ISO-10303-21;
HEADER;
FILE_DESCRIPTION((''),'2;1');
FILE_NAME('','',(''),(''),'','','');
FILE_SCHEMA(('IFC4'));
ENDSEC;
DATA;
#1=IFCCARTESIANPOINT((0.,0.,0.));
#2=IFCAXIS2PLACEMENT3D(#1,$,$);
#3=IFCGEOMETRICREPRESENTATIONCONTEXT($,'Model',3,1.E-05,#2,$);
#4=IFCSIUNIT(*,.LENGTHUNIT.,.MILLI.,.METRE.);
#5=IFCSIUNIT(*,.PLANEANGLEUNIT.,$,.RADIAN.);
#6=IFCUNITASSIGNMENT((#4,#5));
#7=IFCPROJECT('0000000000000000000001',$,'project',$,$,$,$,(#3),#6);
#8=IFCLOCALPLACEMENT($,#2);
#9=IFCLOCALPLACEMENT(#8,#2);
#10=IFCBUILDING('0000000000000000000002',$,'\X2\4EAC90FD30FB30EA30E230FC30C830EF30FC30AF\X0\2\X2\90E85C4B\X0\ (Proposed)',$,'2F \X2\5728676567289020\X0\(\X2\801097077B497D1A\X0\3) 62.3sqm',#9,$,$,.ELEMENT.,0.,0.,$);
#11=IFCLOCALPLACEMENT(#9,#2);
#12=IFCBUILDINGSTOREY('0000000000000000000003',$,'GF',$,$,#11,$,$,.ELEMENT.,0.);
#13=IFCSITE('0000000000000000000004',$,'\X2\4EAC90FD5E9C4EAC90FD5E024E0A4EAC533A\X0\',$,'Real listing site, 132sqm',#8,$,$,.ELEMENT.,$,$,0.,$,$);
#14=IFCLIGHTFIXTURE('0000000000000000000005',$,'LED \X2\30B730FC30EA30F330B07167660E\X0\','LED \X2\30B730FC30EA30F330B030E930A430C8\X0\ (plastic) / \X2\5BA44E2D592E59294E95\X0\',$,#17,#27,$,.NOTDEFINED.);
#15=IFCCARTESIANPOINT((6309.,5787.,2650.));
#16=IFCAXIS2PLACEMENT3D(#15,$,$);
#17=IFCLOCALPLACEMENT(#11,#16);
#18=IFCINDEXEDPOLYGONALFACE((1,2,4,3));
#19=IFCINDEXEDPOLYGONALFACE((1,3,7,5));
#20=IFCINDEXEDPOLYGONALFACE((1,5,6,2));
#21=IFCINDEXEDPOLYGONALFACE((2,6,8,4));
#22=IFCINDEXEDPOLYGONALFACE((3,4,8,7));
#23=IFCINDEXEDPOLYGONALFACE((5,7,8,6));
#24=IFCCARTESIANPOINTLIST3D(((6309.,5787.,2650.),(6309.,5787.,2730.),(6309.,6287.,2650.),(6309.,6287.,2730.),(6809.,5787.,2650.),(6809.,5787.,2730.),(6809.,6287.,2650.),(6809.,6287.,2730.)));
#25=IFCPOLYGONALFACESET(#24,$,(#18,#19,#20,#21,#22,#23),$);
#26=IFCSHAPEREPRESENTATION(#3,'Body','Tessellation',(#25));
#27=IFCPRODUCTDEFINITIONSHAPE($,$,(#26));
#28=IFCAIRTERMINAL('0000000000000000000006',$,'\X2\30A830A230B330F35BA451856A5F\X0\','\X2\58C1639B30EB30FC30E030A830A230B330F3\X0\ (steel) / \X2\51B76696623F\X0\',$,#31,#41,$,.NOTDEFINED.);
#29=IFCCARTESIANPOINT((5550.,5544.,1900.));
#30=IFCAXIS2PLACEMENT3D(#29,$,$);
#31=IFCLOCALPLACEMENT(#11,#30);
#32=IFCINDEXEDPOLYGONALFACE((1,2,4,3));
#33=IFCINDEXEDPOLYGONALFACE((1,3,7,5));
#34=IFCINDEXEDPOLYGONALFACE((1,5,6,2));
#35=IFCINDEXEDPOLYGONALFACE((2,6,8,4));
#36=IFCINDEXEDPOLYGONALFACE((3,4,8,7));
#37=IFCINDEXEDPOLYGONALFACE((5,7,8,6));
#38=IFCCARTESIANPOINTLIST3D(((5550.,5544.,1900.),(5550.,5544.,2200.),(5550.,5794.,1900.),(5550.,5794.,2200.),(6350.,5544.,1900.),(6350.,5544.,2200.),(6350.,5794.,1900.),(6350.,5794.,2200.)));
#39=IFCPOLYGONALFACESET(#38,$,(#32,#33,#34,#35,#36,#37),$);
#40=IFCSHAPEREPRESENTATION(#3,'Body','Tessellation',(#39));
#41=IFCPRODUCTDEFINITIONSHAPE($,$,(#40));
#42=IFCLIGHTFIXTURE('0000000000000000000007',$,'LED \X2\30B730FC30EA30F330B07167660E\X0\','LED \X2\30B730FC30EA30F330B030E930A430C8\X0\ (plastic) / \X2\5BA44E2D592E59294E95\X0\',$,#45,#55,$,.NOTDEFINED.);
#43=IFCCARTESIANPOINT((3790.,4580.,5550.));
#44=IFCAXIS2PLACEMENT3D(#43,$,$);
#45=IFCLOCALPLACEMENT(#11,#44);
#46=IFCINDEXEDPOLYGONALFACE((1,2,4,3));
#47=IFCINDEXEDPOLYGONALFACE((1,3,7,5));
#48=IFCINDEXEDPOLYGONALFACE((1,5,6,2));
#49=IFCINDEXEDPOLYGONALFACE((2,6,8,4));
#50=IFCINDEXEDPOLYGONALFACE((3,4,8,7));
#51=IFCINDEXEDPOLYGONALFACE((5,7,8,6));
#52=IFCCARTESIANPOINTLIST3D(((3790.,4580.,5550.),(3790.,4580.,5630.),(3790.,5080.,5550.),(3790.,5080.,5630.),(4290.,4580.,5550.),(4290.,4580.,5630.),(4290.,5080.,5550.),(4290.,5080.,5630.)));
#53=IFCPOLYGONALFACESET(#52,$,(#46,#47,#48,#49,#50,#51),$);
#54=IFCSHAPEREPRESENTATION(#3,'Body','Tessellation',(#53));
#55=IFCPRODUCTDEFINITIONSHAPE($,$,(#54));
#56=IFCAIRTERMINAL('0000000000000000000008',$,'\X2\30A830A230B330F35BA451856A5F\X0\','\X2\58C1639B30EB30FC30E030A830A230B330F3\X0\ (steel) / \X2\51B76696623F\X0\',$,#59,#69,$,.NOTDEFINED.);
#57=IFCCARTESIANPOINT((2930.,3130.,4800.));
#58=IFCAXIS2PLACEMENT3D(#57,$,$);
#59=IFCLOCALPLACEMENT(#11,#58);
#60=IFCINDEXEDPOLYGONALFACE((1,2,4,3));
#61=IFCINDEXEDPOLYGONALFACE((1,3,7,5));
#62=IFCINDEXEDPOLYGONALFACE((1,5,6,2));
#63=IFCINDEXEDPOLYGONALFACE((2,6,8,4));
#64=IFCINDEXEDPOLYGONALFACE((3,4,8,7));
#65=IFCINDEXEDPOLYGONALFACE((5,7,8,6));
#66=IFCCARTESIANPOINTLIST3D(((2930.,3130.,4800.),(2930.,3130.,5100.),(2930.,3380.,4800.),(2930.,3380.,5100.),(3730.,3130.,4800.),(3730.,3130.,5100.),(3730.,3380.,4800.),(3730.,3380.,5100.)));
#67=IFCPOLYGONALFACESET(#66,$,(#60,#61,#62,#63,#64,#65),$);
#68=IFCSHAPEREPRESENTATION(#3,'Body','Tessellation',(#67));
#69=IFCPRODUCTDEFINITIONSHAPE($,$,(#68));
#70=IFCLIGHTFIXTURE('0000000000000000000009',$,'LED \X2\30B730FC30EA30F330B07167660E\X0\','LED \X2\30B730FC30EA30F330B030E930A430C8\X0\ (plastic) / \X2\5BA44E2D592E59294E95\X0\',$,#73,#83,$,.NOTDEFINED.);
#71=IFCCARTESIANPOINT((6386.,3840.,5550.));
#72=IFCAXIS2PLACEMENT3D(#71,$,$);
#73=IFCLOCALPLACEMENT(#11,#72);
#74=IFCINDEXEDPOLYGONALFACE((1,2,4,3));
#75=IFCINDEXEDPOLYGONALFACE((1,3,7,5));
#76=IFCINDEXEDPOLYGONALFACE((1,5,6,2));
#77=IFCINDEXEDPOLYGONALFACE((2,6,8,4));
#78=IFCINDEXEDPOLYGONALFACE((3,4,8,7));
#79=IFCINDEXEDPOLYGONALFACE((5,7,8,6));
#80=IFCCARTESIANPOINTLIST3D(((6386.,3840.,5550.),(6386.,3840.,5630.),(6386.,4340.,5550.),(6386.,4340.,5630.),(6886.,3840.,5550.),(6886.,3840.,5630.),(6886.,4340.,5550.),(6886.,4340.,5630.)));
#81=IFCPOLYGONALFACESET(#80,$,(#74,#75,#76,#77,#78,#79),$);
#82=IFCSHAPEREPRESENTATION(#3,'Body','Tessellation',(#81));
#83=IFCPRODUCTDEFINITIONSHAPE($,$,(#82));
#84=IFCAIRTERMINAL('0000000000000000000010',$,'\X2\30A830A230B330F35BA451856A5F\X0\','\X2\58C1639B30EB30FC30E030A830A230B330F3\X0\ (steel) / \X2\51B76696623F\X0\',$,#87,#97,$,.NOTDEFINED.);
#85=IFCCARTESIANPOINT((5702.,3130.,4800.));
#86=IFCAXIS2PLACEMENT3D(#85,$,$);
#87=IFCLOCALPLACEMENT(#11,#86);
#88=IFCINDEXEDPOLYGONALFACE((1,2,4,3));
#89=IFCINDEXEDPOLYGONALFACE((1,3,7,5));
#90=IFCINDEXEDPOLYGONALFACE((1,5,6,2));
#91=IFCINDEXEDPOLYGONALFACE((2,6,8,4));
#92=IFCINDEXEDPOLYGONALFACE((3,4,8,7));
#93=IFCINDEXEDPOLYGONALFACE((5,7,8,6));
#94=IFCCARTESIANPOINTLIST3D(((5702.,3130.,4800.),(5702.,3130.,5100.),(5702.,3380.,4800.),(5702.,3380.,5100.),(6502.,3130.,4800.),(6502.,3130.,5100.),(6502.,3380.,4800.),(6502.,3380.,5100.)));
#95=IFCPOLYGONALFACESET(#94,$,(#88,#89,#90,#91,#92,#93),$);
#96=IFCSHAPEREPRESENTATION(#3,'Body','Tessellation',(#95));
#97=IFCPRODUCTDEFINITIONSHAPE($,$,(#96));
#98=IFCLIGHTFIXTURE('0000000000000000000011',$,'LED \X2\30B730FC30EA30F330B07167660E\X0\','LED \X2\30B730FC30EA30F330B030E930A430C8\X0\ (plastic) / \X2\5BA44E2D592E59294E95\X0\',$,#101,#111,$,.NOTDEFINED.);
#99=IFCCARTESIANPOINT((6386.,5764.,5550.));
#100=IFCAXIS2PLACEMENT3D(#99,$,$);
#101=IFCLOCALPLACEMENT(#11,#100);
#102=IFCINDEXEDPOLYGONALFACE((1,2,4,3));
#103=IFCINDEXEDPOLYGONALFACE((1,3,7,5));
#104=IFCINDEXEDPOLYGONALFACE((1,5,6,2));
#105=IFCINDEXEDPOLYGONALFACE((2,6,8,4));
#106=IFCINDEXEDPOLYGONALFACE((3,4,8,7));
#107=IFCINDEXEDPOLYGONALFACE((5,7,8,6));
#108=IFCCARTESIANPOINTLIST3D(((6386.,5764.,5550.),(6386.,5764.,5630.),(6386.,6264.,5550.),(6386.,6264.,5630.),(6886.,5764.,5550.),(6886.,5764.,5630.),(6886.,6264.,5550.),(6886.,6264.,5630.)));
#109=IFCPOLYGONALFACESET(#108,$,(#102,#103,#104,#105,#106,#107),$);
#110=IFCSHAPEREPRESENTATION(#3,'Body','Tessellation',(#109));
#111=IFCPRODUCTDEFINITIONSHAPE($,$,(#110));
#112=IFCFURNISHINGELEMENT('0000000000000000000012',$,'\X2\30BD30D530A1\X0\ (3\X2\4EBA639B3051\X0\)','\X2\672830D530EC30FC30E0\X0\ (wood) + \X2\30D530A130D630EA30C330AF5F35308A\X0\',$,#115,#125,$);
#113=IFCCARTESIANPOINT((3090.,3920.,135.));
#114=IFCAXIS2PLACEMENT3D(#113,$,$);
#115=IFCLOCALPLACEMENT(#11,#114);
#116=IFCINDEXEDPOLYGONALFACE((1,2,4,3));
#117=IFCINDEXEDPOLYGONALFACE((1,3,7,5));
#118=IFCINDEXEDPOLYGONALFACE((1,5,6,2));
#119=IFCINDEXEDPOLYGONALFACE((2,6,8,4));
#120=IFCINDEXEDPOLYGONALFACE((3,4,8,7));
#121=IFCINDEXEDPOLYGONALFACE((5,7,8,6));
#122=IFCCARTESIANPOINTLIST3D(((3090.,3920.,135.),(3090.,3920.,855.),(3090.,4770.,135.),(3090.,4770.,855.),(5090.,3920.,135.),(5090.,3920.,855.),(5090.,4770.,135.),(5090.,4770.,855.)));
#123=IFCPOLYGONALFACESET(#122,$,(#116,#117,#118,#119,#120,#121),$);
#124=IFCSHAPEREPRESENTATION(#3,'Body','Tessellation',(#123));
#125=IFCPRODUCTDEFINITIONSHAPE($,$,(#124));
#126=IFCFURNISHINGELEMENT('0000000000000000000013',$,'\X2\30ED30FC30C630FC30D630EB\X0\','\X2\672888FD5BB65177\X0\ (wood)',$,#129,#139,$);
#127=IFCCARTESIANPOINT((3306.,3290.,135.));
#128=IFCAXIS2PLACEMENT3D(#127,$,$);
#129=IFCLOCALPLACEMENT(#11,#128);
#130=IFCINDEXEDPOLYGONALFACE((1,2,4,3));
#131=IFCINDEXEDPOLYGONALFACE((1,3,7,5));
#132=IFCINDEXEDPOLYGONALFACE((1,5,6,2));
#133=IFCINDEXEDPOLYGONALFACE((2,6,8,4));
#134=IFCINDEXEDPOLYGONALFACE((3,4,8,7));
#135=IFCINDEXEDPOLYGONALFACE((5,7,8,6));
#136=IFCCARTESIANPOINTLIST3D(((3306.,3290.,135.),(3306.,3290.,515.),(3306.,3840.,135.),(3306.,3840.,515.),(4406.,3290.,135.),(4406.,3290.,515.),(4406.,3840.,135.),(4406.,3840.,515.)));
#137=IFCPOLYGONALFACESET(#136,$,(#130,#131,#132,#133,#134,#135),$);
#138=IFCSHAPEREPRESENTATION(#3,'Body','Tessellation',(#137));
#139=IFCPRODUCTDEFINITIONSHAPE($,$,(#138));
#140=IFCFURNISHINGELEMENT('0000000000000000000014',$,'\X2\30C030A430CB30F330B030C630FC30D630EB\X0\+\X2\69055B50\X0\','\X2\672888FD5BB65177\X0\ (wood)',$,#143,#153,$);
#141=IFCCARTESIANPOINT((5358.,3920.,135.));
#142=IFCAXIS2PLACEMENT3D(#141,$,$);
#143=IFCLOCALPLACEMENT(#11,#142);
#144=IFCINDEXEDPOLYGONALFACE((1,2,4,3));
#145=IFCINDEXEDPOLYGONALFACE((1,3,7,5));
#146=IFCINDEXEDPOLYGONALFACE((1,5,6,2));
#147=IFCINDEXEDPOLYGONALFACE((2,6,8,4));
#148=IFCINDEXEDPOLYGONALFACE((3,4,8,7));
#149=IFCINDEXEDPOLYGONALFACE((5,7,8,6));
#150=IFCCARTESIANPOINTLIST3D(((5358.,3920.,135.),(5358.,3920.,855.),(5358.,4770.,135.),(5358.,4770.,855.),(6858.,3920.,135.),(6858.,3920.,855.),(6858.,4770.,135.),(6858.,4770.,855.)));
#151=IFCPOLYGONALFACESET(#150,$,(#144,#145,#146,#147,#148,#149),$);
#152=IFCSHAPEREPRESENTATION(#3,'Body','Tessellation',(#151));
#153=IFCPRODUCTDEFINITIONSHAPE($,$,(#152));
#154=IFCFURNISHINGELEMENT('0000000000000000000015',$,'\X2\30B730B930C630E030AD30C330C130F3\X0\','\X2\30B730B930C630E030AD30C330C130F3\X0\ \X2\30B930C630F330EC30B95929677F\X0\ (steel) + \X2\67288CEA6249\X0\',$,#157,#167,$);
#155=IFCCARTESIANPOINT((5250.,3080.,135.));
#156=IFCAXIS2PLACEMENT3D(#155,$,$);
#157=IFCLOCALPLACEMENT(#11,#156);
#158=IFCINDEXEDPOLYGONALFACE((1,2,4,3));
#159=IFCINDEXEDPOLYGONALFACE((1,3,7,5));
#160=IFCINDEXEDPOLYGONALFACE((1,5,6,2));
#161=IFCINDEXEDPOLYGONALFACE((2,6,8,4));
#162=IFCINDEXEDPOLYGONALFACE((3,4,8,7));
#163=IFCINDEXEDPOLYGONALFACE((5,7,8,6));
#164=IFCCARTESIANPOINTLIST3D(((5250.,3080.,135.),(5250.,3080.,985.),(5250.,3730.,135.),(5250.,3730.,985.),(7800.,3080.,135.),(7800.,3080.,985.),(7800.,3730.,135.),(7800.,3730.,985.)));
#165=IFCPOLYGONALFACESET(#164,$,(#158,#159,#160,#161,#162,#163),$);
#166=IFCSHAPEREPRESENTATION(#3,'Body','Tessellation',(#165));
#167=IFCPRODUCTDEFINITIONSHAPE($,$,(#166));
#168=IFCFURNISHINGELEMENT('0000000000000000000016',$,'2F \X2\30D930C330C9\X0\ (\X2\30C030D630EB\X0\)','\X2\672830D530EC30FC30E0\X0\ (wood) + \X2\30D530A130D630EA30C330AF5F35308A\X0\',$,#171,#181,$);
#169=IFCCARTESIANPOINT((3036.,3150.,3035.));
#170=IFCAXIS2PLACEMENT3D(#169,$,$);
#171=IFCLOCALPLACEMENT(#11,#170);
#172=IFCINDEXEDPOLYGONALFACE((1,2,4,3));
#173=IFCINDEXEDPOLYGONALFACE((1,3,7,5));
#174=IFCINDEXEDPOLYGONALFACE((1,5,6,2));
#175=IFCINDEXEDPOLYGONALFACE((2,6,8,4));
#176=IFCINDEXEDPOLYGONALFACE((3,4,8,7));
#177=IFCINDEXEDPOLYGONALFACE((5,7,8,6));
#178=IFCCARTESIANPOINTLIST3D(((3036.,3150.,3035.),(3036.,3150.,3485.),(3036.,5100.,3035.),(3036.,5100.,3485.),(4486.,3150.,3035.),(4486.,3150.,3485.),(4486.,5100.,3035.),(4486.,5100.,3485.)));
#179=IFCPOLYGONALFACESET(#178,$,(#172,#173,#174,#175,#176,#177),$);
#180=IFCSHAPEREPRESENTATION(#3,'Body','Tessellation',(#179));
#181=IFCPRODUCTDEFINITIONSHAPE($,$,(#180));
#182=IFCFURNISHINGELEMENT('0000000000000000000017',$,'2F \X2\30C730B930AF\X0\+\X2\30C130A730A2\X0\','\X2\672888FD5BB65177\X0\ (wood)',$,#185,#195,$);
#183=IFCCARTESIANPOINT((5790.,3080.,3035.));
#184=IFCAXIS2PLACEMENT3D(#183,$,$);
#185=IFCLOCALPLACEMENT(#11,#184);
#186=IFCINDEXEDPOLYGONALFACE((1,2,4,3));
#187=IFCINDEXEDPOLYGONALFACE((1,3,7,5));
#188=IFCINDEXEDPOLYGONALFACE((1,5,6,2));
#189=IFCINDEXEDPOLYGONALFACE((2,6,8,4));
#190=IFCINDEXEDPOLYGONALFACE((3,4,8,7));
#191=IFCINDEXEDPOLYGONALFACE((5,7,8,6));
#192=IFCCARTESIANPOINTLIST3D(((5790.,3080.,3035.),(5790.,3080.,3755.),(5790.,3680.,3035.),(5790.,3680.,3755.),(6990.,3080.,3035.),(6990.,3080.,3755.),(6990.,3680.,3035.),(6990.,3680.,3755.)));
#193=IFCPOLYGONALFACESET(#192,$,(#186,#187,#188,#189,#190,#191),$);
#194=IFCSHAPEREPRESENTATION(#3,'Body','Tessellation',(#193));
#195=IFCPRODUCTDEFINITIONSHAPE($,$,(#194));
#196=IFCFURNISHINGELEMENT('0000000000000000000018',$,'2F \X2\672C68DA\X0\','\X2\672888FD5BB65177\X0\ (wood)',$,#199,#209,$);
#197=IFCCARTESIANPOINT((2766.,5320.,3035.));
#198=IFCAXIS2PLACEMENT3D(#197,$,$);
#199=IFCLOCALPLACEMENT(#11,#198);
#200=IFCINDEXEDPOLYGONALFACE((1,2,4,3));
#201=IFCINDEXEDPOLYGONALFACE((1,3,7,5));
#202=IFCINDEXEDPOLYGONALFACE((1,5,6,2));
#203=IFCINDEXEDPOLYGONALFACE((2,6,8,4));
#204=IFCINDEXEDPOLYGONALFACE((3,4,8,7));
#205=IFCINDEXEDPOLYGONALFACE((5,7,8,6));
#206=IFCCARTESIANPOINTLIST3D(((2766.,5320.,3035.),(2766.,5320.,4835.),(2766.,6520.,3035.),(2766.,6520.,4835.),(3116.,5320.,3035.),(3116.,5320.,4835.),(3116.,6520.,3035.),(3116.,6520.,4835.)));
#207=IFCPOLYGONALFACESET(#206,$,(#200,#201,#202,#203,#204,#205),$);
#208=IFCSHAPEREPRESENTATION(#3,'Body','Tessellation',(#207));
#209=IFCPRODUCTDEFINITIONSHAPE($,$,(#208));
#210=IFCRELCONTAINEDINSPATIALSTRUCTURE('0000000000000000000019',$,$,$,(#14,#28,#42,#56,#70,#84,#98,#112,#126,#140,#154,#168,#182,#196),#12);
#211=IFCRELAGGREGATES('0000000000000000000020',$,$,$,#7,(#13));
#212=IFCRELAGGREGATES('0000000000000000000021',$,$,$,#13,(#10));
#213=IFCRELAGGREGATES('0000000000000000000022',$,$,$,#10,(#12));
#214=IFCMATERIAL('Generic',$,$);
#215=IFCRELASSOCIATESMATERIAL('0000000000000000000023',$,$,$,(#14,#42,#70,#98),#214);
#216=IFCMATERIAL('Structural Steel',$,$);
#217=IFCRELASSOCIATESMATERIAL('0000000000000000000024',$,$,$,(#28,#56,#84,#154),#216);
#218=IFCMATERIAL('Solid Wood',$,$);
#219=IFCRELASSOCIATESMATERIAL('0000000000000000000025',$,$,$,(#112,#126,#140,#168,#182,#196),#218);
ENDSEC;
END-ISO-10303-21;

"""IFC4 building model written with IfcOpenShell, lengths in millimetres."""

from ifc_helpers import new_model, si_unit, frame, frame_2d, origin, place, context, project, spatial, rectangle, extrude, material, element, save


model = new_model("IFC4")

# Units and contexts
model_context = context("Model", 3, precision=1e-05, world=origin())
ifc_project = project(units=[si_unit("LENGTHUNIT", "METRE", prefix="MILLI"), si_unit("PLANEANGLEUNIT", "RADIAN")], contexts=[model_context])

# Site, building, storey
site_placement = place(None, origin())
site = spatial("IfcSite", under=ifc_project, at=site_placement, Name="京都府京都市上京区", ObjectType="Real listing site, 132sqm", CompositionType="ELEMENT", RefElevation=0.0)
building_placement = place(site_placement, origin())
building = spatial("IfcBuilding", under=site, at=building_placement, Name="京都・リモートワーク2部屋 (Proposed)", ObjectType="2F 在来木造(耐震等級3) 62.3sqm", CompositionType="ELEMENT", ElevationOfRefHeight=0.0, ElevationOfTerrain=0.0)
storey_placement = place(building_placement, origin())
storey = spatial("IfcBuildingStorey", under=building, at=storey_placement, Name="GF", CompositionType="ELEMENT", Elevation=0.0)

# Shared definitions
ifc_material_1 = material(Name="Solid Wood")

# Shared definitions
ifc_material_2 = material(Name="Structural Steel")

# Shared definitions
ifc_material_3 = material(Name="Generic")

# Light fixture
light_fixture_1_placement = place(storey_placement, frame((6309.0, 5787.0, 2650.0)))
element("IfcLightFixture", 1, at=light_fixture_1_placement, inside=storey, material=ifc_material_3, Name="LED シーリング照明", Description="LED シーリングライト (plastic) / 室中央天井", PredefinedType="NOTDEFINED", context=model_context, shape_type="SweptSolid", body=[
    extrude(rectangle(XDim=500.0, YDim=500.0, at=frame_2d((250.0, 250.0))), frame((6309.0, 5787.0, 2650.0)), (0.0, 0.0, 1.0), 80.0),
])

# Air terminal
air_terminal_1_placement = place(storey_placement, frame((5550.0, 5544.0, 1900.0)))
element("IfcAirTerminal", 2, at=air_terminal_1_placement, inside=storey, material=ifc_material_2, Name="エアコン室内機", Description="壁掛ルームエアコン (steel) / 冷暖房", PredefinedType="NOTDEFINED", context=model_context, shape_type="SweptSolid", body=[
    extrude(rectangle(XDim=800.0, YDim=250.0, at=frame_2d((400.0, 125.0))), frame((5550.0, 5544.0, 1900.0)), (0.0, 0.0, 1.0), 300.0),
])

# Light fixture
light_fixture_2_placement = place(storey_placement, frame((3790.0, 4580.0, 5550.0)))
element("IfcLightFixture", 3, at=light_fixture_2_placement, inside=storey, material=ifc_material_3, Name="LED シーリング照明", Description="LED シーリングライト (plastic) / 室中央天井", PredefinedType="NOTDEFINED", context=model_context, shape_type="SweptSolid", body=[
    extrude(rectangle(XDim=500.0, YDim=500.0, at=frame_2d((250.0, 250.0))), frame((3790.0, 4580.0, 5550.0)), (0.0, 0.0, 1.0), 80.0),
])

# Air terminal
air_terminal_2_placement = place(storey_placement, frame((2930.0, 3130.0, 4800.0)))
element("IfcAirTerminal", 4, at=air_terminal_2_placement, inside=storey, material=ifc_material_2, Name="エアコン室内機", Description="壁掛ルームエアコン (steel) / 冷暖房", PredefinedType="NOTDEFINED", context=model_context, shape_type="SweptSolid", body=[
    extrude(rectangle(XDim=800.0, YDim=250.0, at=frame_2d((400.0, 125.0))), frame((2930.0, 3130.0, 4800.0)), (0.0, 0.0, 1.0), 300.0),
])

# Light fixture
light_fixture_3_placement = place(storey_placement, frame((6386.0, 3840.0, 5550.0)))
element("IfcLightFixture", 5, at=light_fixture_3_placement, inside=storey, material=ifc_material_3, Name="LED シーリング照明", Description="LED シーリングライト (plastic) / 室中央天井", PredefinedType="NOTDEFINED", context=model_context, shape_type="SweptSolid", body=[
    extrude(rectangle(XDim=500.0, YDim=500.0, at=frame_2d((250.0, 250.0))), frame((6386.0, 3840.0, 5550.0)), (0.0, 0.0, 1.0), 80.0),
])

# Air terminal
air_terminal_3_placement = place(storey_placement, frame((5702.0, 3130.0, 4800.0)))
element("IfcAirTerminal", 6, at=air_terminal_3_placement, inside=storey, material=ifc_material_2, Name="エアコン室内機", Description="壁掛ルームエアコン (steel) / 冷暖房", PredefinedType="NOTDEFINED", context=model_context, shape_type="SweptSolid", body=[
    extrude(rectangle(XDim=800.0, YDim=250.0, at=frame_2d((400.0, 125.0))), frame((5702.0, 3130.0, 4800.0)), (0.0, 0.0, 1.0), 300.0),
])

# Light fixture
light_fixture_4_placement = place(storey_placement, frame((6386.0, 5764.0, 5550.0)))
element("IfcLightFixture", 7, at=light_fixture_4_placement, inside=storey, material=ifc_material_3, Name="LED シーリング照明", Description="LED シーリングライト (plastic) / 室中央天井", PredefinedType="NOTDEFINED", context=model_context, shape_type="SweptSolid", body=[
    extrude(rectangle(XDim=500.0, YDim=500.0, at=frame_2d((250.0, 250.0))), frame((6386.0, 5764.0, 5550.0)), (0.0, 0.0, 1.0), 80.0),
])

# Furnishing elements
furnishing_1_placement = place(storey_placement, frame((3090.0, 3920.0, 135.0)))
element("IfcFurnishingElement", 8, at=furnishing_1_placement, inside=storey, material=ifc_material_1, Name="ソファ (3人掛け)", Description="木フレーム (wood) + ファブリック張り", context=model_context, shape_type="SweptSolid", body=[
    extrude(rectangle(XDim=2000.0, YDim=850.0, at=frame_2d((1000.0, 425.0))), frame((3090.0, 3920.0, 135.0)), (0.0, 0.0, 1.0), 720.0),
])
furnishing_2_placement = place(storey_placement, frame((3306.0, 3290.0, 135.0)))
element("IfcFurnishingElement", 9, at=furnishing_2_placement, inside=storey, material=ifc_material_1, Name="ローテーブル", Description="木製家具 (wood)", context=model_context, shape_type="SweptSolid", body=[
    extrude(rectangle(XDim=1100.0, YDim=550.0, at=frame_2d((550.0, 275.0))), frame((3306.0, 3290.0, 135.0)), (0.0, 0.0, 1.0), 380.0),
])
furnishing_3_placement = place(storey_placement, frame((5358.0, 3920.0, 135.0)))
element("IfcFurnishingElement", 10, at=furnishing_3_placement, inside=storey, material=ifc_material_1, Name="ダイニングテーブル+椅子", Description="木製家具 (wood)", context=model_context, shape_type="SweptSolid", body=[
    extrude(rectangle(XDim=1500.0, YDim=850.0, at=frame_2d((750.0, 425.0))), frame((5358.0, 3920.0, 135.0)), (0.0, 0.0, 1.0), 720.0),
])
furnishing_4_placement = place(storey_placement, frame((5250.0, 3080.0, 135.0)))
element("IfcFurnishingElement", 11, at=furnishing_4_placement, inside=storey, material=ifc_material_2, Name="システムキッチン", Description="システムキッチン ステンレス天板 (steel) + 木質扉", context=model_context, shape_type="SweptSolid", body=[
    extrude(rectangle(XDim=2550.0, YDim=650.0, at=frame_2d((1275.0, 325.0))), frame((5250.0, 3080.0, 135.0)), (0.0, 0.0, 1.0), 850.0),
])
furnishing_5_placement = place(storey_placement, frame((3036.0, 3150.0, 3035.0)))
element("IfcFurnishingElement", 12, at=furnishing_5_placement, inside=storey, material=ifc_material_1, Name="2F ベッド (ダブル)", Description="木フレーム (wood) + ファブリック張り", context=model_context, shape_type="SweptSolid", body=[
    extrude(rectangle(XDim=1450.0, YDim=1950.0, at=frame_2d((725.0, 975.0))), frame((3036.0, 3150.0, 3035.0)), (0.0, 0.0, 1.0), 450.0),
])
furnishing_6_placement = place(storey_placement, frame((5790.0, 3080.0, 3035.0)))
element("IfcFurnishingElement", 13, at=furnishing_6_placement, inside=storey, material=ifc_material_1, Name="2F デスク+チェア", Description="木製家具 (wood)", context=model_context, shape_type="SweptSolid", body=[
    extrude(rectangle(XDim=1200.0, YDim=600.0, at=frame_2d((600.0, 300.0))), frame((5790.0, 3080.0, 3035.0)), (0.0, 0.0, 1.0), 720.0),
])
furnishing_7_placement = place(storey_placement, frame((2766.0, 5320.0, 3035.0)))
element("IfcFurnishingElement", 14, at=furnishing_7_placement, inside=storey, material=ifc_material_1, Name="2F 本棚", Description="木製家具 (wood)", context=model_context, shape_type="SweptSolid", body=[
    extrude(rectangle(XDim=350.0, YDim=1200.0, at=frame_2d((175.0, 600.0))), frame((2766.0, 5320.0, 3035.0)), (0.0, 0.0, 1.0), 1800.0),
])

save(model, "model.ifc")
